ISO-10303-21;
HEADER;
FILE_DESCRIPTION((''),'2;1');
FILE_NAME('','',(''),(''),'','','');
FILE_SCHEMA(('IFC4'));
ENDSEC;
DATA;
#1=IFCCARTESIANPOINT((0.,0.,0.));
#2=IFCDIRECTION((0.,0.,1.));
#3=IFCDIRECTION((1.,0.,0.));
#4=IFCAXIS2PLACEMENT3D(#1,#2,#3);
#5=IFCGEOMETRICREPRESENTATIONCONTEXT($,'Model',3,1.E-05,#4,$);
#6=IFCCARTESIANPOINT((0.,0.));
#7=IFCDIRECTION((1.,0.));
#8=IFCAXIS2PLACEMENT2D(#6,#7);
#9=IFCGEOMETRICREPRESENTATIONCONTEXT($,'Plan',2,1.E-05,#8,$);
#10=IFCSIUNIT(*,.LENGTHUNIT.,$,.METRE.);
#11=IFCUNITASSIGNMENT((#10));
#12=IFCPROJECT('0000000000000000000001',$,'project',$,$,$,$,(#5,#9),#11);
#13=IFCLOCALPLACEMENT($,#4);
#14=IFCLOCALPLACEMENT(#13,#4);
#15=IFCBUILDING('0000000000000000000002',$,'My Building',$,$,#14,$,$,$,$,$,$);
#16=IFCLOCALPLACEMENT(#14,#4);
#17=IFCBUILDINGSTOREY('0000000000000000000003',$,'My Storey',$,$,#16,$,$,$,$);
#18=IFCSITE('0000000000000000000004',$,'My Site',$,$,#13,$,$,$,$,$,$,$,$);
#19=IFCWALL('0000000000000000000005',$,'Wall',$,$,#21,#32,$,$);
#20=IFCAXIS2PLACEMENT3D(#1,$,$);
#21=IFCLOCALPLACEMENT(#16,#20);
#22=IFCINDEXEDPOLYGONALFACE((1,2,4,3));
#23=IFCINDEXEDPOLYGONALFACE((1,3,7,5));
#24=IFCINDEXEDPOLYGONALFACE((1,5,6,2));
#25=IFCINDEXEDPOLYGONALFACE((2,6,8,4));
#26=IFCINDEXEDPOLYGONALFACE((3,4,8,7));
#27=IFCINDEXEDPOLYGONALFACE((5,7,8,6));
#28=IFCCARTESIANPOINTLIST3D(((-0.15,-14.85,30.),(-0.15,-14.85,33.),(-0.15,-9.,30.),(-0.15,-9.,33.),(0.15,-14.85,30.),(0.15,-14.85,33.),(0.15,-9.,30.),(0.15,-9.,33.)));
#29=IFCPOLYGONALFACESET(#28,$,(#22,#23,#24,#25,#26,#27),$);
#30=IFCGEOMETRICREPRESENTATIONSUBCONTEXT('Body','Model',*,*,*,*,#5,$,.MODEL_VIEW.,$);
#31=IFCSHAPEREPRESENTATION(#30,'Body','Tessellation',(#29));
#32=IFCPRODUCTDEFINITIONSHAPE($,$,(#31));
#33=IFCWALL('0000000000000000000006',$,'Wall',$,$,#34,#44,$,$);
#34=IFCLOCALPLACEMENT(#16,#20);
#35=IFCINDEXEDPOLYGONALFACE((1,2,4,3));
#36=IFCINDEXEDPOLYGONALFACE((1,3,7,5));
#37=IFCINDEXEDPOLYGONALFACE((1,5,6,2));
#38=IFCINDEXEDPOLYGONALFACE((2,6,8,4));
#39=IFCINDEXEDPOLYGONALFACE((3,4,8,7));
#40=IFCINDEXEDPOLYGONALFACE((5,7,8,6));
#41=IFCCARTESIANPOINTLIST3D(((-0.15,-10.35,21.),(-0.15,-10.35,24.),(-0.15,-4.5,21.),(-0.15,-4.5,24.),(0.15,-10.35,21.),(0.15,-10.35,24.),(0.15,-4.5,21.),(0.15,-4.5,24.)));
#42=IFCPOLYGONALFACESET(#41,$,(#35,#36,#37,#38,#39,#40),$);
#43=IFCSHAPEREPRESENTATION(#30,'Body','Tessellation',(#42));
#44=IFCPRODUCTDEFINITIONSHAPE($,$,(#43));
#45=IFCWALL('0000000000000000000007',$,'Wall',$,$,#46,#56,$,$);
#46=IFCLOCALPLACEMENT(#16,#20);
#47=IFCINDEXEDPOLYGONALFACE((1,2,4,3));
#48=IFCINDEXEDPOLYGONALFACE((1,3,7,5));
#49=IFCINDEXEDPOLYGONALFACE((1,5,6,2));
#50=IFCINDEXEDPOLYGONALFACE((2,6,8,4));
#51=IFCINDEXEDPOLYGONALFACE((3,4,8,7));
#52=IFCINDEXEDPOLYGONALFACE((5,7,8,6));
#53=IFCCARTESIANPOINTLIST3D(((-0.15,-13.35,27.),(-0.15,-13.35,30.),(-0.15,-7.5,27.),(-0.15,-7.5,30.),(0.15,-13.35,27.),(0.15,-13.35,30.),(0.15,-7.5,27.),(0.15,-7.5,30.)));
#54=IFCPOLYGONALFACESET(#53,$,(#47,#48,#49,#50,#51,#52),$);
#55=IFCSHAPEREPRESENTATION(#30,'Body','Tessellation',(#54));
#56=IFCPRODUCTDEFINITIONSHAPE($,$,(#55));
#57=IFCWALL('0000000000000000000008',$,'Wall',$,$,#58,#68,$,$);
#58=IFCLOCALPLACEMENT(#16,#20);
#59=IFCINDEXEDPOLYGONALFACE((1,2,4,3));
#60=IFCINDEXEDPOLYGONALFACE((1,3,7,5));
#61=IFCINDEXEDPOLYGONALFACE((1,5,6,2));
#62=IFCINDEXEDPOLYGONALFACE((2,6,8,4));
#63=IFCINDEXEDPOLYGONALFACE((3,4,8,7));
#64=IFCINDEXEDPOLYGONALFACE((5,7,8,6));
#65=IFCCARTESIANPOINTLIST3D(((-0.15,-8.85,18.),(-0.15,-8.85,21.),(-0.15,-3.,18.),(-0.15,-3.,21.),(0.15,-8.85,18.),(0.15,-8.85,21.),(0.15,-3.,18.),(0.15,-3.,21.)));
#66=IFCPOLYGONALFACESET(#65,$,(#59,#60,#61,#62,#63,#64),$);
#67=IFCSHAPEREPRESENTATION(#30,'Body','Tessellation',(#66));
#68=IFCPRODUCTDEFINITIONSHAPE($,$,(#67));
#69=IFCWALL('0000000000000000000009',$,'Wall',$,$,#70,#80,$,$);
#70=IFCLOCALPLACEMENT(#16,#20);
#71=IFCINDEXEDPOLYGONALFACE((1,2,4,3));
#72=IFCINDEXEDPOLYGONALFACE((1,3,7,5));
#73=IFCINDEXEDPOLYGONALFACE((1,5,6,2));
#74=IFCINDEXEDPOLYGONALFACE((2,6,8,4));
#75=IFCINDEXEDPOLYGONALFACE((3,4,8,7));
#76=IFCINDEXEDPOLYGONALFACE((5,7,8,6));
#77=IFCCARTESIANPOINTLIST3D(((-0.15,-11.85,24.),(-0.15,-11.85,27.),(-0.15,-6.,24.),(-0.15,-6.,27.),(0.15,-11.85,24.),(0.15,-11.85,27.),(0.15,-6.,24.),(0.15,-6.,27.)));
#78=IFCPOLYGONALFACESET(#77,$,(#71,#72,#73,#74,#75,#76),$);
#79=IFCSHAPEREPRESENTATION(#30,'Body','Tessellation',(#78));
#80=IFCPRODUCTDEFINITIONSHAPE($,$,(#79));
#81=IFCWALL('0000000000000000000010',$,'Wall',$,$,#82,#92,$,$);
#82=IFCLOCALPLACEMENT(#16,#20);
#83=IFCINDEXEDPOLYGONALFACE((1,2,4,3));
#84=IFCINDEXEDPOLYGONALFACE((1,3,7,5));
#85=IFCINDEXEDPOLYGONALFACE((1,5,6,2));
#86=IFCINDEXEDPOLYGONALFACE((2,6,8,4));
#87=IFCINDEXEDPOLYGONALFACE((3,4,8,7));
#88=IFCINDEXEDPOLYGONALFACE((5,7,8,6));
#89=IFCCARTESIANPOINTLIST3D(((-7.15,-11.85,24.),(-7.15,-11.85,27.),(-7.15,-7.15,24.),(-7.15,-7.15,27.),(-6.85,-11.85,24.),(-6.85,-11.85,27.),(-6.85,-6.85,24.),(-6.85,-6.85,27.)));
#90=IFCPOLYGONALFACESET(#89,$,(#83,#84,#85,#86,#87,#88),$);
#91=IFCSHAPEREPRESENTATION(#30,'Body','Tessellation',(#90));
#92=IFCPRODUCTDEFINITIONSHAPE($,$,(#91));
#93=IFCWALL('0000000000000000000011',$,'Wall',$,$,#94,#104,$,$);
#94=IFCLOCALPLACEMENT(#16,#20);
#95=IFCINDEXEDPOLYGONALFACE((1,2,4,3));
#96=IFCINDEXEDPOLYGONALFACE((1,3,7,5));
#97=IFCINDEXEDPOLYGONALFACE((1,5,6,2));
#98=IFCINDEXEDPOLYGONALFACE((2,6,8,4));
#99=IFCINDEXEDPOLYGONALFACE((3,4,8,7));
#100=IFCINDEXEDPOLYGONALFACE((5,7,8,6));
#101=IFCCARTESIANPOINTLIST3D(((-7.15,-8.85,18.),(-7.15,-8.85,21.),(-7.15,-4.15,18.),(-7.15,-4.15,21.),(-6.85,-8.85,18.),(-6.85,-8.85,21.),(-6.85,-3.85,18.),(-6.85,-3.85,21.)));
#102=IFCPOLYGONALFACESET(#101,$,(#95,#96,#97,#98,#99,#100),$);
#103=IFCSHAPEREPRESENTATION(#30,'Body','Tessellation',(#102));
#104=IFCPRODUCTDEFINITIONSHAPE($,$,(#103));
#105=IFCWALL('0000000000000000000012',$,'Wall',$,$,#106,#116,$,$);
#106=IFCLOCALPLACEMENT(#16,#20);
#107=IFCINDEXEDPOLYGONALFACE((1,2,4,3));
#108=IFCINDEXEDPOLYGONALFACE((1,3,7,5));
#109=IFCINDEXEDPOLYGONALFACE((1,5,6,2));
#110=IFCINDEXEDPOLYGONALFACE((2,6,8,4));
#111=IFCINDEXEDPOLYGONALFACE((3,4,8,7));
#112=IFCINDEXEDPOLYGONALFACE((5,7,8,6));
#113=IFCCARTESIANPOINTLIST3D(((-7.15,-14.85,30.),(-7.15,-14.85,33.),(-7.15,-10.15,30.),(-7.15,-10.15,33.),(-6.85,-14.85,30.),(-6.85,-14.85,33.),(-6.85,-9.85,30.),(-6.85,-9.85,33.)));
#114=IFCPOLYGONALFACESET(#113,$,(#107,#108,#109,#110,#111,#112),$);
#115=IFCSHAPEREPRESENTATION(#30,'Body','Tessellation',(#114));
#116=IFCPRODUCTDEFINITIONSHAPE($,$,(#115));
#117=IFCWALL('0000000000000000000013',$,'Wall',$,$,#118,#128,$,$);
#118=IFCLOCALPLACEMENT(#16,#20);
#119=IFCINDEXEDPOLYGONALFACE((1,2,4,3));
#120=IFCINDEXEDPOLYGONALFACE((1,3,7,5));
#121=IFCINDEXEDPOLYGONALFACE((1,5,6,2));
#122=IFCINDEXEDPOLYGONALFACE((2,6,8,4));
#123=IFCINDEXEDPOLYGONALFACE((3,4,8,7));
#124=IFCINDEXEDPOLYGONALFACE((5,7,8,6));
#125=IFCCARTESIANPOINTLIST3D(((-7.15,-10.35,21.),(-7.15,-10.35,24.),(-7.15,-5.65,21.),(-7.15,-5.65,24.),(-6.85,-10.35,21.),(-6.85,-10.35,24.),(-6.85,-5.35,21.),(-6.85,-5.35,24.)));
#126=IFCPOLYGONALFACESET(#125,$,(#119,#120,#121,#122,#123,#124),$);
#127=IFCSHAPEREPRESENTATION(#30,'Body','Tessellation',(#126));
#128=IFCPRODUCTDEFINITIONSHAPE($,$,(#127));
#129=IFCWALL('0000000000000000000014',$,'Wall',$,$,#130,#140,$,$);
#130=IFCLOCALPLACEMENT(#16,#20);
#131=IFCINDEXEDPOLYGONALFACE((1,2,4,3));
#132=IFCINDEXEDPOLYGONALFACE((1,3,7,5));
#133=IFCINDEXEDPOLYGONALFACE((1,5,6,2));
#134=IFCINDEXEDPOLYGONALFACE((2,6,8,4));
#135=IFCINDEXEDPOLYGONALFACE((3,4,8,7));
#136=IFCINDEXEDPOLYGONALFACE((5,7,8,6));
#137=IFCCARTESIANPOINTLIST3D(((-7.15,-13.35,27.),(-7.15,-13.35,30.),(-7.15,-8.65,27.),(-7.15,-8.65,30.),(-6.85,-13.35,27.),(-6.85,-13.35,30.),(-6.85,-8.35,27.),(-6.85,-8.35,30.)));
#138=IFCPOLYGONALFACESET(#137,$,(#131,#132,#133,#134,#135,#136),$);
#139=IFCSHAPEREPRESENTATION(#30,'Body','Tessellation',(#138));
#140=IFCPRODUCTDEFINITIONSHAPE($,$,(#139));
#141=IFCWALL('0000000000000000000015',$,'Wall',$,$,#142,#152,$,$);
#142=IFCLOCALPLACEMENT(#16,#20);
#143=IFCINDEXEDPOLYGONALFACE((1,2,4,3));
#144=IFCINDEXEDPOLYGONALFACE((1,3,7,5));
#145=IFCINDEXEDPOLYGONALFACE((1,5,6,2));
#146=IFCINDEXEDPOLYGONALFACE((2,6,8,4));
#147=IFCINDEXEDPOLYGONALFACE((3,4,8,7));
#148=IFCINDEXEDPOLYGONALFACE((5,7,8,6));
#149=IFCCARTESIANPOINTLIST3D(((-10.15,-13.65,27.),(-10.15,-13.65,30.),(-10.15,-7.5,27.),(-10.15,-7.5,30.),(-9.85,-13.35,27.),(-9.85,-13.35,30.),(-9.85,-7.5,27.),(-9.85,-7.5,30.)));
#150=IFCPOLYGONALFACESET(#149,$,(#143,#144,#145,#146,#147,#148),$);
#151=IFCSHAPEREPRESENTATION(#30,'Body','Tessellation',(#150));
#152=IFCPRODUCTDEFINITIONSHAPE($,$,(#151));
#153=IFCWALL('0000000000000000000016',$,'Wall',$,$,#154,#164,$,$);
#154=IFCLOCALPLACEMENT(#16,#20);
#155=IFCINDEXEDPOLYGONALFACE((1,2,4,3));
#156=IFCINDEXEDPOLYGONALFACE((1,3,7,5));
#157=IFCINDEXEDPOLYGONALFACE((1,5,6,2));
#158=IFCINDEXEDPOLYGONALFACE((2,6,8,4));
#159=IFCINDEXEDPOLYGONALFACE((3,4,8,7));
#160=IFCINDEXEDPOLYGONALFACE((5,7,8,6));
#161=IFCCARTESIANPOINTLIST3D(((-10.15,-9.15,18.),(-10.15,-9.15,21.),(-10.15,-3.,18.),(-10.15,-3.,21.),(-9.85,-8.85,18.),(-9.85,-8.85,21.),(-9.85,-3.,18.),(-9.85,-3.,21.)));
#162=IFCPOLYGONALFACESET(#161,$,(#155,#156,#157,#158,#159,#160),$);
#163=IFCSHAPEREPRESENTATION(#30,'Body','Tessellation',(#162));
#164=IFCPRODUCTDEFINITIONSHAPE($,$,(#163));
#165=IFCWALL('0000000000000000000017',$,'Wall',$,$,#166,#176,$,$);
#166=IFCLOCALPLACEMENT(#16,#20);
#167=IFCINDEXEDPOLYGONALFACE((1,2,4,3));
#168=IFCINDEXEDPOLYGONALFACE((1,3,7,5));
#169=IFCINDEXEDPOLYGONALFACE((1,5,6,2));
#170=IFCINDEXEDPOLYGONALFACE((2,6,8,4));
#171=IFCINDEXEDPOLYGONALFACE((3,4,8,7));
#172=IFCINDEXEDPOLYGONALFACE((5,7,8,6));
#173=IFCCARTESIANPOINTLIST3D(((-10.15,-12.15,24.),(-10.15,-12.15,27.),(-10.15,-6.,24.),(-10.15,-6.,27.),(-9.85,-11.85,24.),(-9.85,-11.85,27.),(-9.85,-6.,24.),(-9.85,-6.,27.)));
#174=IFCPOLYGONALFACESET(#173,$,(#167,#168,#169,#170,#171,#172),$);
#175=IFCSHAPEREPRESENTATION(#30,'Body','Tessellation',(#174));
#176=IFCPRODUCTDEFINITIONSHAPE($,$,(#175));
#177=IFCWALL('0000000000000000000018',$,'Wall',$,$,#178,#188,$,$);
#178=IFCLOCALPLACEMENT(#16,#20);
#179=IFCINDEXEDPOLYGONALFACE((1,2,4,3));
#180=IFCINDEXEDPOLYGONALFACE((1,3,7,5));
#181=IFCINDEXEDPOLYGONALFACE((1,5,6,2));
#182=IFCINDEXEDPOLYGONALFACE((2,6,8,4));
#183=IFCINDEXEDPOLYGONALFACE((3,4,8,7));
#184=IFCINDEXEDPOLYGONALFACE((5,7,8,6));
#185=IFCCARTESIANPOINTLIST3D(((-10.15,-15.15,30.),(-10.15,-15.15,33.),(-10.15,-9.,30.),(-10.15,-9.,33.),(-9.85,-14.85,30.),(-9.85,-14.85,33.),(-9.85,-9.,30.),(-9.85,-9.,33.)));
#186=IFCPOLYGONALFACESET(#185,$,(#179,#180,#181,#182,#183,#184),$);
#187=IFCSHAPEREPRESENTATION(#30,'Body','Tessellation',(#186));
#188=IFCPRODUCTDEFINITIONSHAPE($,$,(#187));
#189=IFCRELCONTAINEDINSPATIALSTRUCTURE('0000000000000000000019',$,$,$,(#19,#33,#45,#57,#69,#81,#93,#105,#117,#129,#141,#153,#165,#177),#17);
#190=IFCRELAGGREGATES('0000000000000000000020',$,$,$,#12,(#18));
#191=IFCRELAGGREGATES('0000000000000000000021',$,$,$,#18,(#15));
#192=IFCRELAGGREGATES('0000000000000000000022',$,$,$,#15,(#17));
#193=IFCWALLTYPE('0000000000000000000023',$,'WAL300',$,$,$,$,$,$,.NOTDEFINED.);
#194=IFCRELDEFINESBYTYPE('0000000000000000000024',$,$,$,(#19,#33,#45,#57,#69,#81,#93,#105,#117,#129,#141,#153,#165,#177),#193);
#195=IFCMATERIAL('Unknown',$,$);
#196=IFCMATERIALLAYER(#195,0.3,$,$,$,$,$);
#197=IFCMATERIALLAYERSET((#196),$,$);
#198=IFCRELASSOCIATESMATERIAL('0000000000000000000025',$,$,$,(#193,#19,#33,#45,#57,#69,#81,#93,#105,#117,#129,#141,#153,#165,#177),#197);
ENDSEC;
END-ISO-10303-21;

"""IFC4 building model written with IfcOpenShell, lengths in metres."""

from ifc_helpers import new_model, si_unit, frame, origin_with_axes, origin_2d_with_axis, place, context, subcontext, project, spatial, line, indexed_curve, outline, extrude, material, layer, layer_set, layer_usage, type_object, element, save


model = new_model("IFC4")

# Units and contexts
model_context = context("Model", 3, precision=1e-05, world=origin_with_axes())
plan_context = context("Plan", 2, precision=1e-05, world=origin_2d_with_axis())
body_context = subcontext(model_context, "Body", "Model", "MODEL_VIEW")
ifc_project = project(units=[si_unit("LENGTHUNIT", "METRE")], contexts=[model_context, plan_context])

# Site, building, storey
site_placement = place(None, origin_with_axes())
site = spatial("IfcSite", under=ifc_project, at=site_placement, Name="My Site")
building_placement = place(site_placement, origin_with_axes())
building = spatial("IfcBuilding", under=site, at=building_placement, Name="My Building")
storey_placement = place(building_placement, origin_with_axes())
storey = spatial("IfcBuildingStorey", under=building, at=storey_placement, Name="My Storey")

# Walls
ifc_material = material(Name="Unknown")
ifc_layer = layer(ifc_material, 0.3)
ifc_layer_set = layer_set([ifc_layer])
ifc_layer_usage_1 = layer_usage(ifc_layer_set, "AXIS2", "POSITIVE", -0.15)
wall_type = type_object("IfcWallType", Name="WAL300", PredefinedType="NOTDEFINED", material=ifc_layer_set)
wall_1_placement = place(storey_placement, frame((0.0, -15.0, 30.0), z_axis=(0.0, 0.0, 1.0), x_axis=(0.0, 1.0, 0.0)))
element("IfcWall", 1, at=wall_1_placement, inside=storey, type_object=wall_type, material=ifc_layer_usage_1, Name="Wall", context=body_context, shape_type="SweptSolid", body=[
    extrude(outline(indexed_curve([(0.15, -0.15), (0.15, 0.15), (6.0, 0.15), (6.0, -0.15)], segments=[line(1, 2, 3, 4, 1)])), origin_with_axes(), (0.0, 0.0, 1.0), 3.0),
])
ifc_layer_usage_2 = layer_usage(ifc_layer_set, "AXIS2", "POSITIVE", -0.15)
wall_2_placement = place(storey_placement, frame((0.0, -10.5, 21.0), z_axis=(0.0, 0.0, 1.0), x_axis=(0.0, 1.0, 0.0)))
element("IfcWall", 2, at=wall_2_placement, inside=storey, type_object=wall_type, material=ifc_layer_usage_2, Name="Wall", context=body_context, shape_type="SweptSolid", body=[
    extrude(outline(indexed_curve([(0.15, -0.15), (0.15, 0.15), (6.0, 0.15), (6.0, -0.15)], segments=[line(1, 2, 3, 4, 1)])), origin_with_axes(), (0.0, 0.0, 1.0), 3.0),
])
ifc_layer_usage_3 = layer_usage(ifc_layer_set, "AXIS2", "POSITIVE", -0.15)
wall_3_placement = place(storey_placement, frame((0.0, -13.5, 27.0), z_axis=(0.0, 0.0, 1.0), x_axis=(0.0, 1.0, 0.0)))
element("IfcWall", 3, at=wall_3_placement, inside=storey, type_object=wall_type, material=ifc_layer_usage_3, Name="Wall", context=body_context, shape_type="SweptSolid", body=[
    extrude(outline(indexed_curve([(0.15, -0.15), (0.15, 0.15), (6.0, 0.15), (6.0, -0.15)], segments=[line(1, 2, 3, 4, 1)])), origin_with_axes(), (0.0, 0.0, 1.0), 3.0),
])
ifc_layer_usage_4 = layer_usage(ifc_layer_set, "AXIS2", "POSITIVE", -0.15)
wall_4_placement = place(storey_placement, frame((0.0, -9.0, 18.0), z_axis=(0.0, 0.0, 1.0), x_axis=(0.0, 1.0, 0.0)))
element("IfcWall", 4, at=wall_4_placement, inside=storey, type_object=wall_type, material=ifc_layer_usage_4, Name="Wall", context=body_context, shape_type="SweptSolid", body=[
    extrude(outline(indexed_curve([(0.15, -0.15), (0.15, 0.15), (6.0, 0.15), (6.0, -0.15)], segments=[line(1, 2, 3, 4, 1)])), origin_with_axes(), (0.0, 0.0, 1.0), 3.0),
])
ifc_layer_usage_5 = layer_usage(ifc_layer_set, "AXIS2", "POSITIVE", -0.15)
wall_5_placement = place(storey_placement, frame((0.0, -12.0, 24.0), z_axis=(0.0, 0.0, 1.0), x_axis=(0.0, 1.0, 0.0)))
element("IfcWall", 5, at=wall_5_placement, inside=storey, type_object=wall_type, material=ifc_layer_usage_5, Name="Wall", context=body_context, shape_type="SweptSolid", body=[
    extrude(outline(indexed_curve([(0.15, -0.15), (0.15, 0.15), (6.0, 0.15), (6.0, -0.15)], segments=[line(1, 2, 3, 4, 1)])), origin_with_axes(), (0.0, 0.0, 1.0), 3.0),
])
ifc_layer_usage_6 = layer_usage(ifc_layer_set, "AXIS2", "POSITIVE", -0.15)
wall_6_placement = place(storey_placement, frame((-7.0, -12.0, 24.0), z_axis=(0.0, 0.0, 1.0), x_axis=(0.0, 1.0, 0.0)))
element("IfcWall", 6, at=wall_6_placement, inside=storey, type_object=wall_type, material=ifc_layer_usage_6, Name="Wall", context=body_context, shape_type="SweptSolid", body=[
    extrude(outline(indexed_curve([(0.15, -0.15), (0.15, 0.15), (4.85, 0.15), (5.15, -0.15)], segments=[line(1, 2, 3, 4, 1)])), origin_with_axes(), (0.0, 0.0, 1.0), 3.0),
])
ifc_layer_usage_7 = layer_usage(ifc_layer_set, "AXIS2", "POSITIVE", -0.15)
wall_7_placement = place(storey_placement, frame((-7.0, -9.0, 18.0), z_axis=(0.0, 0.0, 1.0), x_axis=(0.0, 1.0, 0.0)))
element("IfcWall", 7, at=wall_7_placement, inside=storey, type_object=wall_type, material=ifc_layer_usage_7, Name="Wall", context=body_context, shape_type="SweptSolid", body=[
    extrude(outline(indexed_curve([(0.15, -0.15), (0.15, 0.15), (4.85, 0.15), (5.15, -0.15)], segments=[line(1, 2, 3, 4, 1)])), origin_with_axes(), (0.0, 0.0, 1.0), 3.0),
])
ifc_layer_usage_8 = layer_usage(ifc_layer_set, "AXIS2", "POSITIVE", -0.15)
wall_8_placement = place(storey_placement, frame((-7.0, -15.0, 30.0), z_axis=(0.0, 0.0, 1.0), x_axis=(0.0, 1.0, 0.0)))
element("IfcWall", 8, at=wall_8_placement, inside=storey, type_object=wall_type, material=ifc_layer_usage_8, Name="Wall", context=body_context, shape_type="SweptSolid", body=[
    extrude(outline(indexed_curve([(0.15, -0.15), (0.15, 0.15), (4.85, 0.15), (5.15, -0.15)], segments=[line(1, 2, 3, 4, 1)])), origin_with_axes(), (0.0, 0.0, 1.0), 3.0),
])
ifc_layer_usage_9 = layer_usage(ifc_layer_set, "AXIS2", "POSITIVE", -0.15)
wall_9_placement = place(storey_placement, frame((-7.0, -10.5, 21.0), z_axis=(0.0, 0.0, 1.0), x_axis=(0.0, 1.0, 0.0)))
element("IfcWall", 9, at=wall_9_placement, inside=storey, type_object=wall_type, material=ifc_layer_usage_9, Name="Wall", context=body_context, shape_type="SweptSolid", body=[
    extrude(outline(indexed_curve([(0.15, -0.15), (0.15, 0.15), (4.85, 0.15), (5.15, -0.15)], segments=[line(1, 2, 3, 4, 1)])), origin_with_axes(), (0.0, 0.0, 1.0), 3.0),
])
ifc_layer_usage_10 = layer_usage(ifc_layer_set, "AXIS2", "POSITIVE", -0.15)
wall_10_placement = place(storey_placement, frame((-7.0, -13.5, 27.0), z_axis=(0.0, 0.0, 1.0), x_axis=(0.0, 1.0, 0.0)))
element("IfcWall", 10, at=wall_10_placement, inside=storey, type_object=wall_type, material=ifc_layer_usage_10, Name="Wall", context=body_context, shape_type="SweptSolid", body=[
    extrude(outline(indexed_curve([(0.15, -0.15), (0.15, 0.15), (4.85, 0.15), (5.15, -0.15)], segments=[line(1, 2, 3, 4, 1)])), origin_with_axes(), (0.0, 0.0, 1.0), 3.0),
])
ifc_layer_usage_11 = layer_usage(ifc_layer_set, "AXIS2", "POSITIVE", -0.15)
wall_11_placement = place(storey_placement, frame((-10.0, -13.5, 27.0), z_axis=(0.0, 0.0, 1.0), x_axis=(0.0, 1.0, 0.0)))
element("IfcWall", 11, at=wall_11_placement, inside=storey, type_object=wall_type, material=ifc_layer_usage_11, Name="Wall", context=body_context, shape_type="SweptSolid", body=[
    extrude(outline(indexed_curve([(0.15, -0.15), (-0.15, 0.15), (6.0, 0.15), (6.0, -0.15)], segments=[line(1, 2, 3, 4, 1)])), origin_with_axes(), (0.0, 0.0, 1.0), 3.0),
])
ifc_layer_usage_12 = layer_usage(ifc_layer_set, "AXIS2", "POSITIVE", -0.15)
wall_12_placement = place(storey_placement, frame((-10.0, -9.0, 18.0), z_axis=(0.0, 0.0, 1.0), x_axis=(0.0, 1.0, 0.0)))
element("IfcWall", 12, at=wall_12_placement, inside=storey, type_object=wall_type, material=ifc_layer_usage_12, Name="Wall", context=body_context, shape_type="SweptSolid", body=[
    extrude(outline(indexed_curve([(0.15, -0.15), (-0.15, 0.15), (6.0, 0.15), (6.0, -0.15)], segments=[line(1, 2, 3, 4, 1)])), origin_with_axes(), (0.0, 0.0, 1.0), 3.0),
])
ifc_layer_usage_13 = layer_usage(ifc_layer_set, "AXIS2", "POSITIVE", -0.15)
wall_13_placement = place(storey_placement, frame((-10.0, -12.0, 24.0), z_axis=(0.0, 0.0, 1.0), x_axis=(0.0, 1.0, 0.0)))
element("IfcWall", 13, at=wall_13_placement, inside=storey, type_object=wall_type, material=ifc_layer_usage_13, Name="Wall", context=body_context, shape_type="SweptSolid", body=[
    extrude(outline(indexed_curve([(0.15, -0.15), (-0.15, 0.15), (6.0, 0.15), (6.0, -0.15)], segments=[line(1, 2, 3, 4, 1)])), origin_with_axes(), (0.0, 0.0, 1.0), 3.0),
])
ifc_layer_usage_14 = layer_usage(ifc_layer_set, "AXIS2", "POSITIVE", -0.15)
wall_14_placement = place(storey_placement, frame((-10.0, -15.0, 30.0), z_axis=(0.0, 0.0, 1.0), x_axis=(0.0, 1.0, 0.0)))
element("IfcWall", 14, at=wall_14_placement, inside=storey, type_object=wall_type, material=ifc_layer_usage_14, Name="Wall", context=body_context, shape_type="SweptSolid", body=[
    extrude(outline(indexed_curve([(0.15, -0.15), (-0.15, 0.15), (6.0, 0.15), (6.0, -0.15)], segments=[line(1, 2, 3, 4, 1)])), origin_with_axes(), (0.0, 0.0, 1.0), 3.0),
])

save(model, "model.ifc")
